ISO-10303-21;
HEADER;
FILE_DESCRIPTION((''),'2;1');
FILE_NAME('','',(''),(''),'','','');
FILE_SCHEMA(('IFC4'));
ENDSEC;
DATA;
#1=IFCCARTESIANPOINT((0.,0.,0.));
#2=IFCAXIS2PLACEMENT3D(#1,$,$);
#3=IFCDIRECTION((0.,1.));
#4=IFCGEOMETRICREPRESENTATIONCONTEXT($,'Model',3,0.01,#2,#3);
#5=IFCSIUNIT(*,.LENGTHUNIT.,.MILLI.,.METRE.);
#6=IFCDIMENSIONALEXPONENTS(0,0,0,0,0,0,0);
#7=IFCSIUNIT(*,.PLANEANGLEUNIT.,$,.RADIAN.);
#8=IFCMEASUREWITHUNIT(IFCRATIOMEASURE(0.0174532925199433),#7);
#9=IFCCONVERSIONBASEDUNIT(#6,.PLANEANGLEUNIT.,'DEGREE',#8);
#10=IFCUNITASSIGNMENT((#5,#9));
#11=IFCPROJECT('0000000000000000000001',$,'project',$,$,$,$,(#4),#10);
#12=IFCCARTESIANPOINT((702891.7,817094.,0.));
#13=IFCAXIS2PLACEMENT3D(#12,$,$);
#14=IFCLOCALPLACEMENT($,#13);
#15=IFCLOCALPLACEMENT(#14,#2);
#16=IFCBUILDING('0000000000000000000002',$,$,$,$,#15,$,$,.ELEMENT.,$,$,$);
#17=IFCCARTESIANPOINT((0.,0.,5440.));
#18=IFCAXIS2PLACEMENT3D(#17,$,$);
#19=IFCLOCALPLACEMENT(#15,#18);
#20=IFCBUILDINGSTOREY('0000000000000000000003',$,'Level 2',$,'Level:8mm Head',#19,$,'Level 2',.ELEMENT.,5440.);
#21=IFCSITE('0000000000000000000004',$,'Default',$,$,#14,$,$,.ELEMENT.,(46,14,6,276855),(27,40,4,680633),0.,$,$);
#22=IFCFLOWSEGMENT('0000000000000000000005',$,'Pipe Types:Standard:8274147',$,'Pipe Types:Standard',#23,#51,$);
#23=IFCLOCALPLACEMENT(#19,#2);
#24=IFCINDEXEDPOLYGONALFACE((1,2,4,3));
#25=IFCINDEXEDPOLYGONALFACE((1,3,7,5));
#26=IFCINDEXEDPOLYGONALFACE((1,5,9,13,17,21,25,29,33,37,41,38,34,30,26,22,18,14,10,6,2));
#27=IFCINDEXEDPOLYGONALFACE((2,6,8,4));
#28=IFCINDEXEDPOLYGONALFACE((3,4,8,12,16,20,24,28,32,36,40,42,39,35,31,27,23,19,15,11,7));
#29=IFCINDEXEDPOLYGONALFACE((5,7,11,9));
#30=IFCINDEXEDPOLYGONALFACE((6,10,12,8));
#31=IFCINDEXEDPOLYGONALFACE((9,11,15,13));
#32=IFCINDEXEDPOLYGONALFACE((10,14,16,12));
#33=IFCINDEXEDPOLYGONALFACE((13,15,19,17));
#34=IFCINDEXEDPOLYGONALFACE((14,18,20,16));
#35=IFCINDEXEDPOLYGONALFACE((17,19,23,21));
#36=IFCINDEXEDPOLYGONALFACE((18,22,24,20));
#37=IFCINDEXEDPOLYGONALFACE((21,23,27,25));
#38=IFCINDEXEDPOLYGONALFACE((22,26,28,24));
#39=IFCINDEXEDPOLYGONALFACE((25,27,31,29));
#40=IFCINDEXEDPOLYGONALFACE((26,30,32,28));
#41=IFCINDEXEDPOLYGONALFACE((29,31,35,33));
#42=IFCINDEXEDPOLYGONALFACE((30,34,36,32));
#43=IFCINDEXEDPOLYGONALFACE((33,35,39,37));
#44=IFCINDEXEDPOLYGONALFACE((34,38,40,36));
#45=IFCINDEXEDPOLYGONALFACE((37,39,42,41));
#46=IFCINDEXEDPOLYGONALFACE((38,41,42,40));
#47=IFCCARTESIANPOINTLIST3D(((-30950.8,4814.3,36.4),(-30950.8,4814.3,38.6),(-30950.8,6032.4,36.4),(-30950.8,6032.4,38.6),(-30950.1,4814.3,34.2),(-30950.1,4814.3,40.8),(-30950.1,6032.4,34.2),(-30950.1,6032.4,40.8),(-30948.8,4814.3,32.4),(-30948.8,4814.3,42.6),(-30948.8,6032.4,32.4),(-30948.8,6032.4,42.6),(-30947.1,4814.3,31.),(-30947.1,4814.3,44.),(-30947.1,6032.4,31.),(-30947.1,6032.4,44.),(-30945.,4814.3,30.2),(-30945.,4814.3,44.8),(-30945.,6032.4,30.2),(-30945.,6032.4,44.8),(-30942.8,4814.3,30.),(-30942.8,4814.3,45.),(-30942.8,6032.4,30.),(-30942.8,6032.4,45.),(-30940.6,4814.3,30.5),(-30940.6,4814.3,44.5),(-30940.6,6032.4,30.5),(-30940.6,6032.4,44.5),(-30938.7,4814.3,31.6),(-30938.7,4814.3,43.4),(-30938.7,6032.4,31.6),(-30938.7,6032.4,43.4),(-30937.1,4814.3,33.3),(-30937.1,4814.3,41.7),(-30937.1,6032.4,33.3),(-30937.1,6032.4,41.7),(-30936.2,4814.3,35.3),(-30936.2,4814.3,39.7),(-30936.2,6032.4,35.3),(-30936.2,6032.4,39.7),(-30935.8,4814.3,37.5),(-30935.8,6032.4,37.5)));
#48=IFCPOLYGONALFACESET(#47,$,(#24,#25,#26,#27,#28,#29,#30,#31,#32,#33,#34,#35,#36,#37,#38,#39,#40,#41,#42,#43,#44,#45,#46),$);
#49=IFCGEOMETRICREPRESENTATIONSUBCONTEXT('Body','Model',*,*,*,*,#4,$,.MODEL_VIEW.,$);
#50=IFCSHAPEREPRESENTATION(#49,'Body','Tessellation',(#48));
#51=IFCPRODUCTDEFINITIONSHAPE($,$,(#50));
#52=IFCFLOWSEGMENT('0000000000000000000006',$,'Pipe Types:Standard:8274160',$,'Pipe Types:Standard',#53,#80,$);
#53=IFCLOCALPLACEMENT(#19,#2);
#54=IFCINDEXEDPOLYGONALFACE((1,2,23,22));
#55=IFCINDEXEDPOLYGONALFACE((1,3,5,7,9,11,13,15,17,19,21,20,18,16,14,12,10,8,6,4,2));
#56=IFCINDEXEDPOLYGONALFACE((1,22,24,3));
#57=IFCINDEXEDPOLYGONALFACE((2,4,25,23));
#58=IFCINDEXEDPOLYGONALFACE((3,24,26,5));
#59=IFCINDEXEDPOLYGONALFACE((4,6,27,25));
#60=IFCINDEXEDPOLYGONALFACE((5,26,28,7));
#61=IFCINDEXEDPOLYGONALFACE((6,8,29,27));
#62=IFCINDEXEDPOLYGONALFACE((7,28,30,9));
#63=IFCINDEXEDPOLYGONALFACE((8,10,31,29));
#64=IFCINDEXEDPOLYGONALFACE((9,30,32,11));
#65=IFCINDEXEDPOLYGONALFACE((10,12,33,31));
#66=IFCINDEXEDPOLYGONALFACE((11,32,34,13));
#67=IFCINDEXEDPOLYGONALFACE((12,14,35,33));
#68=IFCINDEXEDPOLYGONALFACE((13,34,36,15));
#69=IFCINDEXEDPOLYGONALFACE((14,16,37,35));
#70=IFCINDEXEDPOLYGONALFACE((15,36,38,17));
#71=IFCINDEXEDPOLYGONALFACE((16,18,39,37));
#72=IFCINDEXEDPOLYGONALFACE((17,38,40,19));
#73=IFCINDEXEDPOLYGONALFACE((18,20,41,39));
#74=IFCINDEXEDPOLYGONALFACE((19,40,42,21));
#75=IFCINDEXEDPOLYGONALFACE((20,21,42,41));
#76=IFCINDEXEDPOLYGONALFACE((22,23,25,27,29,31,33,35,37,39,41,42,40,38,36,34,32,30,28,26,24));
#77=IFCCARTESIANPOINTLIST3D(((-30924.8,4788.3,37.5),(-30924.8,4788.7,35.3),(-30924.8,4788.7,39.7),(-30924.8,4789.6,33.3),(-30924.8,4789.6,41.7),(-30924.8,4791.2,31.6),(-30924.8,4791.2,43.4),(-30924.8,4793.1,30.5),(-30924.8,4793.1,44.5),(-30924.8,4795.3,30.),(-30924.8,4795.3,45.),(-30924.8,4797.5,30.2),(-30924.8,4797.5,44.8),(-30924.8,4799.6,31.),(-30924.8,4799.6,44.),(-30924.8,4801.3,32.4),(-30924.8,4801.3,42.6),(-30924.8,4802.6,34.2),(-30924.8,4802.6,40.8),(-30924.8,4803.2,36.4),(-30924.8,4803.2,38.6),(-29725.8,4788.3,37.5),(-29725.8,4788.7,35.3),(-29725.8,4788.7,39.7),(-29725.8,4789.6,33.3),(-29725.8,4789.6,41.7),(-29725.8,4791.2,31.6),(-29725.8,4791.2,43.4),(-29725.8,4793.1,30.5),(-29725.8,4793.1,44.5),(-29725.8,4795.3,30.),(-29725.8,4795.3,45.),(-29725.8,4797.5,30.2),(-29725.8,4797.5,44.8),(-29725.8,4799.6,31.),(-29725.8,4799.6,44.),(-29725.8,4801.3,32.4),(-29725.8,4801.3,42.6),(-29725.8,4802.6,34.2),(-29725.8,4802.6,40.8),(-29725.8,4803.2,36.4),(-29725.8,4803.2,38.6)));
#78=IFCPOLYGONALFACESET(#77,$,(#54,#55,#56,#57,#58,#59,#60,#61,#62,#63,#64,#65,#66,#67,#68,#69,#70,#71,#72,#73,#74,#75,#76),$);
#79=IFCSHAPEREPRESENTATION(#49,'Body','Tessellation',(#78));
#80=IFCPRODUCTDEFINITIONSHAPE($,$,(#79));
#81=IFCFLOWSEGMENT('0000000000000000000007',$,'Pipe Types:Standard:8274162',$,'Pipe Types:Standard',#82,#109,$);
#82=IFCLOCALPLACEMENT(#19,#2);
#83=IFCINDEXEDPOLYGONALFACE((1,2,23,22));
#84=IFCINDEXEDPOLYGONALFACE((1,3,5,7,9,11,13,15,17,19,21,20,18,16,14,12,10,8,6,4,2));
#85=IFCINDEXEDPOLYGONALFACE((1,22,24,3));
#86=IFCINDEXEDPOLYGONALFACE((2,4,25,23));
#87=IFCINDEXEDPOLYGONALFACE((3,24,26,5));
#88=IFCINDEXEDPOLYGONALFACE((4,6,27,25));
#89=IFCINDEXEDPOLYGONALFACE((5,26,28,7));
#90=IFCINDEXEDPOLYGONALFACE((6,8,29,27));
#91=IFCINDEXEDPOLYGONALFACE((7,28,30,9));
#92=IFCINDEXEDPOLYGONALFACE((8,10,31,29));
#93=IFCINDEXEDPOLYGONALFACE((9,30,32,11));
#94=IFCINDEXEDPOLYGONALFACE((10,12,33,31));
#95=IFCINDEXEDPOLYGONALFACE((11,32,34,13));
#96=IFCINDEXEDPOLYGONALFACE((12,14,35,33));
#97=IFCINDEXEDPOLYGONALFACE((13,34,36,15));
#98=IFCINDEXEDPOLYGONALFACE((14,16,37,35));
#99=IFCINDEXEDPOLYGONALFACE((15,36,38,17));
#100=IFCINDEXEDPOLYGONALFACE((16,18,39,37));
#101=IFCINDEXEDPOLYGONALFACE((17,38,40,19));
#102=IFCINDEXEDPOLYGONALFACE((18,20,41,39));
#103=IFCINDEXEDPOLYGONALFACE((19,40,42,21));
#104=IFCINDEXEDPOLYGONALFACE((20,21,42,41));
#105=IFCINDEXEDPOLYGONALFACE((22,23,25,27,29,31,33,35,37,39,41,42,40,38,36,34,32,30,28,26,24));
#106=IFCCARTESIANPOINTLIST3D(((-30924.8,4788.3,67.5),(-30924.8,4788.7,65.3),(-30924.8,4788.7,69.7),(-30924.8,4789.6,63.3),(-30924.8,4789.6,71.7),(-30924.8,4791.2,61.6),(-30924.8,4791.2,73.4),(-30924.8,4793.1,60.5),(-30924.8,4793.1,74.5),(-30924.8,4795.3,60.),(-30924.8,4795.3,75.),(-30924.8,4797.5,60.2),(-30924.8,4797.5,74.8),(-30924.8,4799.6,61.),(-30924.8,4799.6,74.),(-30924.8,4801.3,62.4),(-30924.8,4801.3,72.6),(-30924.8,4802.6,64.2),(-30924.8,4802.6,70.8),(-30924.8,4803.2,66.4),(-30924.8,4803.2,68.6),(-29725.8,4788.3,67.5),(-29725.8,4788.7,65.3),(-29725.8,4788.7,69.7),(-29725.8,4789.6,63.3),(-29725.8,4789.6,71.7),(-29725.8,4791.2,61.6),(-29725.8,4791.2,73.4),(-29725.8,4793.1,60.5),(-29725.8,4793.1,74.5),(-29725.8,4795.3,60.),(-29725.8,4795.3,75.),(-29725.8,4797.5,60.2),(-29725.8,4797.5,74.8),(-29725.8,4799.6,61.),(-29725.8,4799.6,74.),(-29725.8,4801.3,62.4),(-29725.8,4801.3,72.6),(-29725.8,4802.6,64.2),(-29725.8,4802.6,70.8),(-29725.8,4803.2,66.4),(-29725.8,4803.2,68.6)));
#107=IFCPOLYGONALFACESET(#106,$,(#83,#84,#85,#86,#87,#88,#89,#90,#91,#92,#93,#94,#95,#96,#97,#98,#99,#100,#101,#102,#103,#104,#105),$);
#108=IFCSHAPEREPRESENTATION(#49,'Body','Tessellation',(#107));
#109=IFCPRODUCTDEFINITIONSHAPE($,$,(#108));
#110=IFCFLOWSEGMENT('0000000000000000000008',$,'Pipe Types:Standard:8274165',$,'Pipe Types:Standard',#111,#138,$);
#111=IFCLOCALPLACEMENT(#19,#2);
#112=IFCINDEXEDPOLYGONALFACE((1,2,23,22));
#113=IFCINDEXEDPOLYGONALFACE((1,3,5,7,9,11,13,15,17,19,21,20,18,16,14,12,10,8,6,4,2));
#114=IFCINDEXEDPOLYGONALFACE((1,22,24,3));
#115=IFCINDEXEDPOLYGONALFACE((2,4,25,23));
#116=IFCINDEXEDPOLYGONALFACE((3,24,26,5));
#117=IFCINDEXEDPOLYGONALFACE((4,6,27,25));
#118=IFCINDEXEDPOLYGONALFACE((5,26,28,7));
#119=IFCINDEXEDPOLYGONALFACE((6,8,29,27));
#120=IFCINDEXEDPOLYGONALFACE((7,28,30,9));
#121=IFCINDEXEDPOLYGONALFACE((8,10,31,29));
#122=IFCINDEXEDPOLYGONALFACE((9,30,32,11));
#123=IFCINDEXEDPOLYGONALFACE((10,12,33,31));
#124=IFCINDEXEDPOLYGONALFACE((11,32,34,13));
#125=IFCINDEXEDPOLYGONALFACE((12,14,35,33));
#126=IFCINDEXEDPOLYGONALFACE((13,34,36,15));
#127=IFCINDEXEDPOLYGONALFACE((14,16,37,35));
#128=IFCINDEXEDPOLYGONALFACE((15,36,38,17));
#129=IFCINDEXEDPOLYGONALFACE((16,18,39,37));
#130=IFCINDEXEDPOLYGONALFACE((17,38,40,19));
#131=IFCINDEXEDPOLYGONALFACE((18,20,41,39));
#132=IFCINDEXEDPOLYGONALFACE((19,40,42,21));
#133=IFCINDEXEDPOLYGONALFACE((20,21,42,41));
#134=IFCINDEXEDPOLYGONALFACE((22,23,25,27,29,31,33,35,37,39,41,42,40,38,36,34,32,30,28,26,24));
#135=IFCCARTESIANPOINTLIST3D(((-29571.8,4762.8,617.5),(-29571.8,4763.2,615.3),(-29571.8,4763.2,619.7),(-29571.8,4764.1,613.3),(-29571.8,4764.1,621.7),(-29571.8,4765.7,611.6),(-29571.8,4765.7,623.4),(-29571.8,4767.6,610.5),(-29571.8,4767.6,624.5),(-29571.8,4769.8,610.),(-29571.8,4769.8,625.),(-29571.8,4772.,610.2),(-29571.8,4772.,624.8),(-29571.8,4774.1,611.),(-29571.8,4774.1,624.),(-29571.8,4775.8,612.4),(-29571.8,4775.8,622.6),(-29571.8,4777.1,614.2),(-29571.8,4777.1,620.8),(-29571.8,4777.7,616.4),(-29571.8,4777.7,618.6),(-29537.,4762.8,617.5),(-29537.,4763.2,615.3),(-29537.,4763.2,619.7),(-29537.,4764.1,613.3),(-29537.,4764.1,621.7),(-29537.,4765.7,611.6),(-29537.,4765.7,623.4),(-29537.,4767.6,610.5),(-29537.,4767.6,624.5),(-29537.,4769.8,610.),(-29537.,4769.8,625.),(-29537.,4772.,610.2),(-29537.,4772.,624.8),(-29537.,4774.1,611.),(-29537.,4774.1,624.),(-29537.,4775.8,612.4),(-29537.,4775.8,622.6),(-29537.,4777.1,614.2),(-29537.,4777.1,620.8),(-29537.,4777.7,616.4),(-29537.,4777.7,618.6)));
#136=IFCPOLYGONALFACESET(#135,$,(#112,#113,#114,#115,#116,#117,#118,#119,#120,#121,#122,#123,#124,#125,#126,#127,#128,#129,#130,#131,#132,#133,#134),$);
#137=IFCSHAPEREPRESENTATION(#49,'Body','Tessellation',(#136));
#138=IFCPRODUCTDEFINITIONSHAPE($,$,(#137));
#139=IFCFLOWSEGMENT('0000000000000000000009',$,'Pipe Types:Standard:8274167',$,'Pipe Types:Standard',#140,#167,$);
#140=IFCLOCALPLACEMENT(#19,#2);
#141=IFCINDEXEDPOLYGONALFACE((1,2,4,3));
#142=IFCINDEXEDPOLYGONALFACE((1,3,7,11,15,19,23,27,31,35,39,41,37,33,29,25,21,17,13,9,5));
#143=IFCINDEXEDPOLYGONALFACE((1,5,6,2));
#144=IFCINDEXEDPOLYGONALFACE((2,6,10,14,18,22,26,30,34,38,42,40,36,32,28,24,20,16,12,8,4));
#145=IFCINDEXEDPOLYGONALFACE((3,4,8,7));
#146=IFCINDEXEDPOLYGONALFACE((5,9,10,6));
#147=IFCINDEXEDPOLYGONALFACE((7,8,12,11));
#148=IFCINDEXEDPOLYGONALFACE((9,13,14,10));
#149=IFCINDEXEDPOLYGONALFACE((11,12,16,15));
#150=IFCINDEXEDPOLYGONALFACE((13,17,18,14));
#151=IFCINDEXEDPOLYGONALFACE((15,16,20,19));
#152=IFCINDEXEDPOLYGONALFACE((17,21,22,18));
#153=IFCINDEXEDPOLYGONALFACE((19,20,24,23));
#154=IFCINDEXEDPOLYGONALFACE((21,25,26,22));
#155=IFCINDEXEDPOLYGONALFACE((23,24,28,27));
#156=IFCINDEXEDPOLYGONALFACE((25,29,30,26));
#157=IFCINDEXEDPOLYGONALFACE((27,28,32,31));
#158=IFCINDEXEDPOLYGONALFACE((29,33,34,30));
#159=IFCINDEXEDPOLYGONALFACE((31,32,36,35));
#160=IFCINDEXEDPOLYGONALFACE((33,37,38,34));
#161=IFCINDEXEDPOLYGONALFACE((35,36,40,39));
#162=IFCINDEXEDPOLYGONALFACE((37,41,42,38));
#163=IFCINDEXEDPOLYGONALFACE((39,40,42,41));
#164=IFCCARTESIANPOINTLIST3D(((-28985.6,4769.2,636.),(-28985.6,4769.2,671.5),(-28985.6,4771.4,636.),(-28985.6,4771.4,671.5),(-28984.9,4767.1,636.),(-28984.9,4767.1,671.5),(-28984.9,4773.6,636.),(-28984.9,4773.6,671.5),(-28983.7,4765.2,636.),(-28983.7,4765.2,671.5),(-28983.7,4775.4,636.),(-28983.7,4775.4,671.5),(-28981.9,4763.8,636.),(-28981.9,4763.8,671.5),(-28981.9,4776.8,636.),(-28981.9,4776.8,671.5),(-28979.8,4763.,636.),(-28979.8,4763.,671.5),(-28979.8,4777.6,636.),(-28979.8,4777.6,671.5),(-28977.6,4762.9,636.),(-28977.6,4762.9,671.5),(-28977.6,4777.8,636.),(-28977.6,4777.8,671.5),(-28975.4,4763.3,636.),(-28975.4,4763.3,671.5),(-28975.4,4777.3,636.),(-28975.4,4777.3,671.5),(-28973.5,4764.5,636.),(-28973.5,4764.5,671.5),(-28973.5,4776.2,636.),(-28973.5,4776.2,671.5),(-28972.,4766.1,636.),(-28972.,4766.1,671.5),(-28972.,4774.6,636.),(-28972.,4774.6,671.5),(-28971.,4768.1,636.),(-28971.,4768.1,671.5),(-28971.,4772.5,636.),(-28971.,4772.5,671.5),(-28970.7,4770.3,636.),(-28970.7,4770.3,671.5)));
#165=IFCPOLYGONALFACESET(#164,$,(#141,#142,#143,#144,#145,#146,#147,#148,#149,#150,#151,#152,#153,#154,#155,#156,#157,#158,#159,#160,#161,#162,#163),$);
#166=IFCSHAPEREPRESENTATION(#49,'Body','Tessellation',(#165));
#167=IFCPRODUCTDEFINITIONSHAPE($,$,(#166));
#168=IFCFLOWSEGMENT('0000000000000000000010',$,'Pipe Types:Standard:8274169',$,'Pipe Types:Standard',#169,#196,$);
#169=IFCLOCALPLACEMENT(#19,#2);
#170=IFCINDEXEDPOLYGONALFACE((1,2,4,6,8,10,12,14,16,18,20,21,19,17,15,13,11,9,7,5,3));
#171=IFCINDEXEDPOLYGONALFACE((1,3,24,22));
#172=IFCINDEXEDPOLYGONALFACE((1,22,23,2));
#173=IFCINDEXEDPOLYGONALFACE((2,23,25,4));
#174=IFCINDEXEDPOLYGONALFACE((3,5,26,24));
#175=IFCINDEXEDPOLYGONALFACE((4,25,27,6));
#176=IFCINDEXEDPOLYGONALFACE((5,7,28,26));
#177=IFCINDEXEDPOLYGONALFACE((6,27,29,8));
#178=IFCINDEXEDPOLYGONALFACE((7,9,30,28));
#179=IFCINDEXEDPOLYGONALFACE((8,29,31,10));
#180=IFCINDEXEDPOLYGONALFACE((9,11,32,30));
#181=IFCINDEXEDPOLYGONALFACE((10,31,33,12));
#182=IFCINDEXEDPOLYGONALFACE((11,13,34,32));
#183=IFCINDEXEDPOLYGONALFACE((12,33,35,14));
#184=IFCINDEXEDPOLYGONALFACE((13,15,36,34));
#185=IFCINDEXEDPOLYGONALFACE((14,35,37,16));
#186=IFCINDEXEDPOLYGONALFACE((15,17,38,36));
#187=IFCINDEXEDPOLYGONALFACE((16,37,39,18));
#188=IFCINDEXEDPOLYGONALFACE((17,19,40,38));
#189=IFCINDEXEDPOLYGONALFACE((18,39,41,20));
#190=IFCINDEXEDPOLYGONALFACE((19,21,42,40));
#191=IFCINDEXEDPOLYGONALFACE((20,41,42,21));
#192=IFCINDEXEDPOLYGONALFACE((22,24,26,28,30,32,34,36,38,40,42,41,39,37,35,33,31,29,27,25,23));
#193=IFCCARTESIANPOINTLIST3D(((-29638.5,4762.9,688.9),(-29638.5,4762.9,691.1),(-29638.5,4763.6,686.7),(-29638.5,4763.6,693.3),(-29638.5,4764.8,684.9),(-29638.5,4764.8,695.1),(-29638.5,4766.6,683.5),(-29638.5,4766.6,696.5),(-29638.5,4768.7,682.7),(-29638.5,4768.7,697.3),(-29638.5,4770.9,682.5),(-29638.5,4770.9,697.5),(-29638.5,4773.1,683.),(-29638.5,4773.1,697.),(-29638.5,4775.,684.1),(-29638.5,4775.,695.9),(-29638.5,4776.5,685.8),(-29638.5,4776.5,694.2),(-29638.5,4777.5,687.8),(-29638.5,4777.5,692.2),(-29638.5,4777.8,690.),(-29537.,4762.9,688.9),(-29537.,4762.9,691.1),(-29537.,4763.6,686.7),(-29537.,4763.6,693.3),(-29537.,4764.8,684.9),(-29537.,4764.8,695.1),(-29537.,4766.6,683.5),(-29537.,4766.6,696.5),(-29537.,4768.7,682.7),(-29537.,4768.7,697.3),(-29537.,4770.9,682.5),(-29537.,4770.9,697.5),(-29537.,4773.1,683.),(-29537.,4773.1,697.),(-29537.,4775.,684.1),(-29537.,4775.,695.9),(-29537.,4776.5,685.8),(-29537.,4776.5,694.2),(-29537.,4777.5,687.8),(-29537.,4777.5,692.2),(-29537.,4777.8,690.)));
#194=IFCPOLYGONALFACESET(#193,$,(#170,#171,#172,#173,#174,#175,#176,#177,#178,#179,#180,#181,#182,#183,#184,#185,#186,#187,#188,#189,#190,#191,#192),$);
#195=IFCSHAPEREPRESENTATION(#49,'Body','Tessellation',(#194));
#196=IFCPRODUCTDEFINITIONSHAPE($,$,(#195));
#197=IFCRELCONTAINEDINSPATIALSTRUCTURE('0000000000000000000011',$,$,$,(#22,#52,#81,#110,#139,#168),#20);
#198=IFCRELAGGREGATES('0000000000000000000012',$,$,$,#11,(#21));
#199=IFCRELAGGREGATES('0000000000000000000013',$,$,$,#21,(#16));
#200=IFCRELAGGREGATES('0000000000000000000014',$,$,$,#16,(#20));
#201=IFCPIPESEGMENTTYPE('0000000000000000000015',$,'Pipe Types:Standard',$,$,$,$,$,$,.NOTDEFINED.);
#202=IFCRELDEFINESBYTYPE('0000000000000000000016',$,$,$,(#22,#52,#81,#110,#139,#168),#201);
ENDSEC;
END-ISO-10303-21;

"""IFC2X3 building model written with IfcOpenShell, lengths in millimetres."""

from ifc_helpers import new_model, entity, si_unit, converted_unit, direction, frame, frame_2d, origin, origin_2d_with_axis, place, context, subcontext, project, spatial, circle, extrude, type_object, element, save


model = new_model("IFC2X3")

# Units and contexts
model_context = context("Model", 3, precision=0.01, world=origin(), true_north=direction((0.0, 1.0)))
body_context = subcontext(model_context, "Body", "Model", "MODEL_VIEW")
ifc_project = project(units=[si_unit("LENGTHUNIT", "METRE", prefix="MILLI"), converted_unit("PLANEANGLEUNIT", "DEGREE", entity("IfcRatioMeasure", 0.0174532925199433), si_unit("PLANEANGLEUNIT", "RADIAN"), dimensions=[0, 0, 0, 0, 0, 0, 0])], contexts=[model_context])

# Site, building, storey
site_placement = place(None, frame((702891.7, 817094.0, 0.0)))
site = spatial("IfcSite", under=ifc_project, at=site_placement, Name="Default", CompositionType="ELEMENT", RefLatitude=(46, 14, 6, 276855), RefLongitude=(27, 40, 4, 680633), RefElevation=0.0)
building_placement = place(site_placement, origin())
building = spatial("IfcBuilding", under=site, at=building_placement, CompositionType="ELEMENT")
storey_placement = place(building_placement, frame((0.0, 0.0, 5440.0)))
storey = spatial("IfcBuildingStorey", under=building, at=storey_placement, Name="Level 2", ObjectType="Level:8mm Head", LongName="Level 2", CompositionType="ELEMENT", Elevation=5440.0)

# Flow segments
pipe_segment_type = type_object("IfcPipeSegmentType", Name="Pipe Types:Standard", PredefinedType="NOTDEFINED")
flow_segment_1_placement = place(storey_placement, origin())
element("IfcFlowSegment", 1, at=flow_segment_1_placement, inside=storey, type_object=pipe_segment_type, Name="Pipe Types:Standard:8274147", ObjectType="Pipe Types:Standard", context=body_context, shape_type="SweptSolid", body=[
    extrude(circle(Radius=7.5, at=origin_2d_with_axis()), frame((-30943.3, 4814.3, 37.5), z_axis=(0.0, 1.0, 0.0), x_axis=(1.0, 0.0, 0.0)), (0.0, 0.0, 1.0), 1218.1),
])
flow_segment_2_placement = place(storey_placement, origin())
element("IfcFlowSegment", 2, at=flow_segment_2_placement, inside=storey, type_object=pipe_segment_type, Name="Pipe Types:Standard:8274160", ObjectType="Pipe Types:Standard", context=body_context, shape_type="SweptSolid", body=[
    extrude(circle(Radius=7.5, at=origin_2d_with_axis()), frame((-30924.8, 4795.8, 37.5), z_axis=(1.0, 0.0, 0.0), x_axis=(0.0, -1.0, 0.0)), (0.0, 0.0, 1.0), 1199.1),
])
flow_segment_3_placement = place(storey_placement, origin())
element("IfcFlowSegment", 3, at=flow_segment_3_placement, inside=storey, type_object=pipe_segment_type, Name="Pipe Types:Standard:8274162", ObjectType="Pipe Types:Standard", context=body_context, shape_type="SweptSolid", body=[
    extrude(circle(Radius=7.5, at=origin_2d_with_axis()), frame((-30924.8, 4795.8, 67.5), z_axis=(1.0, 0.0, 0.0), x_axis=(0.0, -1.0, 0.0)), (0.0, 0.0, 1.0), 1199.1),
])
flow_segment_4_placement = place(storey_placement, origin())
element("IfcFlowSegment", 4, at=flow_segment_4_placement, inside=storey, type_object=pipe_segment_type, Name="Pipe Types:Standard:8274165", ObjectType="Pipe Types:Standard", context=body_context, shape_type="SweptSolid", body=[
    extrude(circle(Radius=7.5, at=origin_2d_with_axis()), frame((-29571.8, 4770.3, 617.5), z_axis=(1.0, 0.0, 0.0), x_axis=(0.0, -1.0, 0.0)), (0.0, 0.0, 1.0), 34.8),
])
flow_segment_5_placement = place(storey_placement, origin())
element("IfcFlowSegment", 5, at=flow_segment_5_placement, inside=storey, type_object=pipe_segment_type, Name="Pipe Types:Standard:8274167", ObjectType="Pipe Types:Standard", context=body_context, shape_type="SweptSolid", body=[
    extrude(circle(Radius=7.5, at=origin_2d_with_axis()), frame((-28978.2, 4770.3, 636.0)), (0.0, 0.0, 1.0), 35.5),
])
flow_segment_6_placement = place(storey_placement, origin())
element("IfcFlowSegment", 6, at=flow_segment_6_placement, inside=storey, type_object=pipe_segment_type, Name="Pipe Types:Standard:8274169", ObjectType="Pipe Types:Standard", context=body_context, shape_type="SweptSolid", body=[
    extrude(circle(Radius=7.5, at=frame_2d((0.0, 0.0), x_axis=(1.0, 0.0))), frame((-29638.5, 4770.3, 690.0), z_axis=(1.0, 0.0, 0.0), x_axis=(0.0, 1.0, 0.0)), (0.0, 0.0, 1.0), 101.5),
])

save(model, "model.ifc")
